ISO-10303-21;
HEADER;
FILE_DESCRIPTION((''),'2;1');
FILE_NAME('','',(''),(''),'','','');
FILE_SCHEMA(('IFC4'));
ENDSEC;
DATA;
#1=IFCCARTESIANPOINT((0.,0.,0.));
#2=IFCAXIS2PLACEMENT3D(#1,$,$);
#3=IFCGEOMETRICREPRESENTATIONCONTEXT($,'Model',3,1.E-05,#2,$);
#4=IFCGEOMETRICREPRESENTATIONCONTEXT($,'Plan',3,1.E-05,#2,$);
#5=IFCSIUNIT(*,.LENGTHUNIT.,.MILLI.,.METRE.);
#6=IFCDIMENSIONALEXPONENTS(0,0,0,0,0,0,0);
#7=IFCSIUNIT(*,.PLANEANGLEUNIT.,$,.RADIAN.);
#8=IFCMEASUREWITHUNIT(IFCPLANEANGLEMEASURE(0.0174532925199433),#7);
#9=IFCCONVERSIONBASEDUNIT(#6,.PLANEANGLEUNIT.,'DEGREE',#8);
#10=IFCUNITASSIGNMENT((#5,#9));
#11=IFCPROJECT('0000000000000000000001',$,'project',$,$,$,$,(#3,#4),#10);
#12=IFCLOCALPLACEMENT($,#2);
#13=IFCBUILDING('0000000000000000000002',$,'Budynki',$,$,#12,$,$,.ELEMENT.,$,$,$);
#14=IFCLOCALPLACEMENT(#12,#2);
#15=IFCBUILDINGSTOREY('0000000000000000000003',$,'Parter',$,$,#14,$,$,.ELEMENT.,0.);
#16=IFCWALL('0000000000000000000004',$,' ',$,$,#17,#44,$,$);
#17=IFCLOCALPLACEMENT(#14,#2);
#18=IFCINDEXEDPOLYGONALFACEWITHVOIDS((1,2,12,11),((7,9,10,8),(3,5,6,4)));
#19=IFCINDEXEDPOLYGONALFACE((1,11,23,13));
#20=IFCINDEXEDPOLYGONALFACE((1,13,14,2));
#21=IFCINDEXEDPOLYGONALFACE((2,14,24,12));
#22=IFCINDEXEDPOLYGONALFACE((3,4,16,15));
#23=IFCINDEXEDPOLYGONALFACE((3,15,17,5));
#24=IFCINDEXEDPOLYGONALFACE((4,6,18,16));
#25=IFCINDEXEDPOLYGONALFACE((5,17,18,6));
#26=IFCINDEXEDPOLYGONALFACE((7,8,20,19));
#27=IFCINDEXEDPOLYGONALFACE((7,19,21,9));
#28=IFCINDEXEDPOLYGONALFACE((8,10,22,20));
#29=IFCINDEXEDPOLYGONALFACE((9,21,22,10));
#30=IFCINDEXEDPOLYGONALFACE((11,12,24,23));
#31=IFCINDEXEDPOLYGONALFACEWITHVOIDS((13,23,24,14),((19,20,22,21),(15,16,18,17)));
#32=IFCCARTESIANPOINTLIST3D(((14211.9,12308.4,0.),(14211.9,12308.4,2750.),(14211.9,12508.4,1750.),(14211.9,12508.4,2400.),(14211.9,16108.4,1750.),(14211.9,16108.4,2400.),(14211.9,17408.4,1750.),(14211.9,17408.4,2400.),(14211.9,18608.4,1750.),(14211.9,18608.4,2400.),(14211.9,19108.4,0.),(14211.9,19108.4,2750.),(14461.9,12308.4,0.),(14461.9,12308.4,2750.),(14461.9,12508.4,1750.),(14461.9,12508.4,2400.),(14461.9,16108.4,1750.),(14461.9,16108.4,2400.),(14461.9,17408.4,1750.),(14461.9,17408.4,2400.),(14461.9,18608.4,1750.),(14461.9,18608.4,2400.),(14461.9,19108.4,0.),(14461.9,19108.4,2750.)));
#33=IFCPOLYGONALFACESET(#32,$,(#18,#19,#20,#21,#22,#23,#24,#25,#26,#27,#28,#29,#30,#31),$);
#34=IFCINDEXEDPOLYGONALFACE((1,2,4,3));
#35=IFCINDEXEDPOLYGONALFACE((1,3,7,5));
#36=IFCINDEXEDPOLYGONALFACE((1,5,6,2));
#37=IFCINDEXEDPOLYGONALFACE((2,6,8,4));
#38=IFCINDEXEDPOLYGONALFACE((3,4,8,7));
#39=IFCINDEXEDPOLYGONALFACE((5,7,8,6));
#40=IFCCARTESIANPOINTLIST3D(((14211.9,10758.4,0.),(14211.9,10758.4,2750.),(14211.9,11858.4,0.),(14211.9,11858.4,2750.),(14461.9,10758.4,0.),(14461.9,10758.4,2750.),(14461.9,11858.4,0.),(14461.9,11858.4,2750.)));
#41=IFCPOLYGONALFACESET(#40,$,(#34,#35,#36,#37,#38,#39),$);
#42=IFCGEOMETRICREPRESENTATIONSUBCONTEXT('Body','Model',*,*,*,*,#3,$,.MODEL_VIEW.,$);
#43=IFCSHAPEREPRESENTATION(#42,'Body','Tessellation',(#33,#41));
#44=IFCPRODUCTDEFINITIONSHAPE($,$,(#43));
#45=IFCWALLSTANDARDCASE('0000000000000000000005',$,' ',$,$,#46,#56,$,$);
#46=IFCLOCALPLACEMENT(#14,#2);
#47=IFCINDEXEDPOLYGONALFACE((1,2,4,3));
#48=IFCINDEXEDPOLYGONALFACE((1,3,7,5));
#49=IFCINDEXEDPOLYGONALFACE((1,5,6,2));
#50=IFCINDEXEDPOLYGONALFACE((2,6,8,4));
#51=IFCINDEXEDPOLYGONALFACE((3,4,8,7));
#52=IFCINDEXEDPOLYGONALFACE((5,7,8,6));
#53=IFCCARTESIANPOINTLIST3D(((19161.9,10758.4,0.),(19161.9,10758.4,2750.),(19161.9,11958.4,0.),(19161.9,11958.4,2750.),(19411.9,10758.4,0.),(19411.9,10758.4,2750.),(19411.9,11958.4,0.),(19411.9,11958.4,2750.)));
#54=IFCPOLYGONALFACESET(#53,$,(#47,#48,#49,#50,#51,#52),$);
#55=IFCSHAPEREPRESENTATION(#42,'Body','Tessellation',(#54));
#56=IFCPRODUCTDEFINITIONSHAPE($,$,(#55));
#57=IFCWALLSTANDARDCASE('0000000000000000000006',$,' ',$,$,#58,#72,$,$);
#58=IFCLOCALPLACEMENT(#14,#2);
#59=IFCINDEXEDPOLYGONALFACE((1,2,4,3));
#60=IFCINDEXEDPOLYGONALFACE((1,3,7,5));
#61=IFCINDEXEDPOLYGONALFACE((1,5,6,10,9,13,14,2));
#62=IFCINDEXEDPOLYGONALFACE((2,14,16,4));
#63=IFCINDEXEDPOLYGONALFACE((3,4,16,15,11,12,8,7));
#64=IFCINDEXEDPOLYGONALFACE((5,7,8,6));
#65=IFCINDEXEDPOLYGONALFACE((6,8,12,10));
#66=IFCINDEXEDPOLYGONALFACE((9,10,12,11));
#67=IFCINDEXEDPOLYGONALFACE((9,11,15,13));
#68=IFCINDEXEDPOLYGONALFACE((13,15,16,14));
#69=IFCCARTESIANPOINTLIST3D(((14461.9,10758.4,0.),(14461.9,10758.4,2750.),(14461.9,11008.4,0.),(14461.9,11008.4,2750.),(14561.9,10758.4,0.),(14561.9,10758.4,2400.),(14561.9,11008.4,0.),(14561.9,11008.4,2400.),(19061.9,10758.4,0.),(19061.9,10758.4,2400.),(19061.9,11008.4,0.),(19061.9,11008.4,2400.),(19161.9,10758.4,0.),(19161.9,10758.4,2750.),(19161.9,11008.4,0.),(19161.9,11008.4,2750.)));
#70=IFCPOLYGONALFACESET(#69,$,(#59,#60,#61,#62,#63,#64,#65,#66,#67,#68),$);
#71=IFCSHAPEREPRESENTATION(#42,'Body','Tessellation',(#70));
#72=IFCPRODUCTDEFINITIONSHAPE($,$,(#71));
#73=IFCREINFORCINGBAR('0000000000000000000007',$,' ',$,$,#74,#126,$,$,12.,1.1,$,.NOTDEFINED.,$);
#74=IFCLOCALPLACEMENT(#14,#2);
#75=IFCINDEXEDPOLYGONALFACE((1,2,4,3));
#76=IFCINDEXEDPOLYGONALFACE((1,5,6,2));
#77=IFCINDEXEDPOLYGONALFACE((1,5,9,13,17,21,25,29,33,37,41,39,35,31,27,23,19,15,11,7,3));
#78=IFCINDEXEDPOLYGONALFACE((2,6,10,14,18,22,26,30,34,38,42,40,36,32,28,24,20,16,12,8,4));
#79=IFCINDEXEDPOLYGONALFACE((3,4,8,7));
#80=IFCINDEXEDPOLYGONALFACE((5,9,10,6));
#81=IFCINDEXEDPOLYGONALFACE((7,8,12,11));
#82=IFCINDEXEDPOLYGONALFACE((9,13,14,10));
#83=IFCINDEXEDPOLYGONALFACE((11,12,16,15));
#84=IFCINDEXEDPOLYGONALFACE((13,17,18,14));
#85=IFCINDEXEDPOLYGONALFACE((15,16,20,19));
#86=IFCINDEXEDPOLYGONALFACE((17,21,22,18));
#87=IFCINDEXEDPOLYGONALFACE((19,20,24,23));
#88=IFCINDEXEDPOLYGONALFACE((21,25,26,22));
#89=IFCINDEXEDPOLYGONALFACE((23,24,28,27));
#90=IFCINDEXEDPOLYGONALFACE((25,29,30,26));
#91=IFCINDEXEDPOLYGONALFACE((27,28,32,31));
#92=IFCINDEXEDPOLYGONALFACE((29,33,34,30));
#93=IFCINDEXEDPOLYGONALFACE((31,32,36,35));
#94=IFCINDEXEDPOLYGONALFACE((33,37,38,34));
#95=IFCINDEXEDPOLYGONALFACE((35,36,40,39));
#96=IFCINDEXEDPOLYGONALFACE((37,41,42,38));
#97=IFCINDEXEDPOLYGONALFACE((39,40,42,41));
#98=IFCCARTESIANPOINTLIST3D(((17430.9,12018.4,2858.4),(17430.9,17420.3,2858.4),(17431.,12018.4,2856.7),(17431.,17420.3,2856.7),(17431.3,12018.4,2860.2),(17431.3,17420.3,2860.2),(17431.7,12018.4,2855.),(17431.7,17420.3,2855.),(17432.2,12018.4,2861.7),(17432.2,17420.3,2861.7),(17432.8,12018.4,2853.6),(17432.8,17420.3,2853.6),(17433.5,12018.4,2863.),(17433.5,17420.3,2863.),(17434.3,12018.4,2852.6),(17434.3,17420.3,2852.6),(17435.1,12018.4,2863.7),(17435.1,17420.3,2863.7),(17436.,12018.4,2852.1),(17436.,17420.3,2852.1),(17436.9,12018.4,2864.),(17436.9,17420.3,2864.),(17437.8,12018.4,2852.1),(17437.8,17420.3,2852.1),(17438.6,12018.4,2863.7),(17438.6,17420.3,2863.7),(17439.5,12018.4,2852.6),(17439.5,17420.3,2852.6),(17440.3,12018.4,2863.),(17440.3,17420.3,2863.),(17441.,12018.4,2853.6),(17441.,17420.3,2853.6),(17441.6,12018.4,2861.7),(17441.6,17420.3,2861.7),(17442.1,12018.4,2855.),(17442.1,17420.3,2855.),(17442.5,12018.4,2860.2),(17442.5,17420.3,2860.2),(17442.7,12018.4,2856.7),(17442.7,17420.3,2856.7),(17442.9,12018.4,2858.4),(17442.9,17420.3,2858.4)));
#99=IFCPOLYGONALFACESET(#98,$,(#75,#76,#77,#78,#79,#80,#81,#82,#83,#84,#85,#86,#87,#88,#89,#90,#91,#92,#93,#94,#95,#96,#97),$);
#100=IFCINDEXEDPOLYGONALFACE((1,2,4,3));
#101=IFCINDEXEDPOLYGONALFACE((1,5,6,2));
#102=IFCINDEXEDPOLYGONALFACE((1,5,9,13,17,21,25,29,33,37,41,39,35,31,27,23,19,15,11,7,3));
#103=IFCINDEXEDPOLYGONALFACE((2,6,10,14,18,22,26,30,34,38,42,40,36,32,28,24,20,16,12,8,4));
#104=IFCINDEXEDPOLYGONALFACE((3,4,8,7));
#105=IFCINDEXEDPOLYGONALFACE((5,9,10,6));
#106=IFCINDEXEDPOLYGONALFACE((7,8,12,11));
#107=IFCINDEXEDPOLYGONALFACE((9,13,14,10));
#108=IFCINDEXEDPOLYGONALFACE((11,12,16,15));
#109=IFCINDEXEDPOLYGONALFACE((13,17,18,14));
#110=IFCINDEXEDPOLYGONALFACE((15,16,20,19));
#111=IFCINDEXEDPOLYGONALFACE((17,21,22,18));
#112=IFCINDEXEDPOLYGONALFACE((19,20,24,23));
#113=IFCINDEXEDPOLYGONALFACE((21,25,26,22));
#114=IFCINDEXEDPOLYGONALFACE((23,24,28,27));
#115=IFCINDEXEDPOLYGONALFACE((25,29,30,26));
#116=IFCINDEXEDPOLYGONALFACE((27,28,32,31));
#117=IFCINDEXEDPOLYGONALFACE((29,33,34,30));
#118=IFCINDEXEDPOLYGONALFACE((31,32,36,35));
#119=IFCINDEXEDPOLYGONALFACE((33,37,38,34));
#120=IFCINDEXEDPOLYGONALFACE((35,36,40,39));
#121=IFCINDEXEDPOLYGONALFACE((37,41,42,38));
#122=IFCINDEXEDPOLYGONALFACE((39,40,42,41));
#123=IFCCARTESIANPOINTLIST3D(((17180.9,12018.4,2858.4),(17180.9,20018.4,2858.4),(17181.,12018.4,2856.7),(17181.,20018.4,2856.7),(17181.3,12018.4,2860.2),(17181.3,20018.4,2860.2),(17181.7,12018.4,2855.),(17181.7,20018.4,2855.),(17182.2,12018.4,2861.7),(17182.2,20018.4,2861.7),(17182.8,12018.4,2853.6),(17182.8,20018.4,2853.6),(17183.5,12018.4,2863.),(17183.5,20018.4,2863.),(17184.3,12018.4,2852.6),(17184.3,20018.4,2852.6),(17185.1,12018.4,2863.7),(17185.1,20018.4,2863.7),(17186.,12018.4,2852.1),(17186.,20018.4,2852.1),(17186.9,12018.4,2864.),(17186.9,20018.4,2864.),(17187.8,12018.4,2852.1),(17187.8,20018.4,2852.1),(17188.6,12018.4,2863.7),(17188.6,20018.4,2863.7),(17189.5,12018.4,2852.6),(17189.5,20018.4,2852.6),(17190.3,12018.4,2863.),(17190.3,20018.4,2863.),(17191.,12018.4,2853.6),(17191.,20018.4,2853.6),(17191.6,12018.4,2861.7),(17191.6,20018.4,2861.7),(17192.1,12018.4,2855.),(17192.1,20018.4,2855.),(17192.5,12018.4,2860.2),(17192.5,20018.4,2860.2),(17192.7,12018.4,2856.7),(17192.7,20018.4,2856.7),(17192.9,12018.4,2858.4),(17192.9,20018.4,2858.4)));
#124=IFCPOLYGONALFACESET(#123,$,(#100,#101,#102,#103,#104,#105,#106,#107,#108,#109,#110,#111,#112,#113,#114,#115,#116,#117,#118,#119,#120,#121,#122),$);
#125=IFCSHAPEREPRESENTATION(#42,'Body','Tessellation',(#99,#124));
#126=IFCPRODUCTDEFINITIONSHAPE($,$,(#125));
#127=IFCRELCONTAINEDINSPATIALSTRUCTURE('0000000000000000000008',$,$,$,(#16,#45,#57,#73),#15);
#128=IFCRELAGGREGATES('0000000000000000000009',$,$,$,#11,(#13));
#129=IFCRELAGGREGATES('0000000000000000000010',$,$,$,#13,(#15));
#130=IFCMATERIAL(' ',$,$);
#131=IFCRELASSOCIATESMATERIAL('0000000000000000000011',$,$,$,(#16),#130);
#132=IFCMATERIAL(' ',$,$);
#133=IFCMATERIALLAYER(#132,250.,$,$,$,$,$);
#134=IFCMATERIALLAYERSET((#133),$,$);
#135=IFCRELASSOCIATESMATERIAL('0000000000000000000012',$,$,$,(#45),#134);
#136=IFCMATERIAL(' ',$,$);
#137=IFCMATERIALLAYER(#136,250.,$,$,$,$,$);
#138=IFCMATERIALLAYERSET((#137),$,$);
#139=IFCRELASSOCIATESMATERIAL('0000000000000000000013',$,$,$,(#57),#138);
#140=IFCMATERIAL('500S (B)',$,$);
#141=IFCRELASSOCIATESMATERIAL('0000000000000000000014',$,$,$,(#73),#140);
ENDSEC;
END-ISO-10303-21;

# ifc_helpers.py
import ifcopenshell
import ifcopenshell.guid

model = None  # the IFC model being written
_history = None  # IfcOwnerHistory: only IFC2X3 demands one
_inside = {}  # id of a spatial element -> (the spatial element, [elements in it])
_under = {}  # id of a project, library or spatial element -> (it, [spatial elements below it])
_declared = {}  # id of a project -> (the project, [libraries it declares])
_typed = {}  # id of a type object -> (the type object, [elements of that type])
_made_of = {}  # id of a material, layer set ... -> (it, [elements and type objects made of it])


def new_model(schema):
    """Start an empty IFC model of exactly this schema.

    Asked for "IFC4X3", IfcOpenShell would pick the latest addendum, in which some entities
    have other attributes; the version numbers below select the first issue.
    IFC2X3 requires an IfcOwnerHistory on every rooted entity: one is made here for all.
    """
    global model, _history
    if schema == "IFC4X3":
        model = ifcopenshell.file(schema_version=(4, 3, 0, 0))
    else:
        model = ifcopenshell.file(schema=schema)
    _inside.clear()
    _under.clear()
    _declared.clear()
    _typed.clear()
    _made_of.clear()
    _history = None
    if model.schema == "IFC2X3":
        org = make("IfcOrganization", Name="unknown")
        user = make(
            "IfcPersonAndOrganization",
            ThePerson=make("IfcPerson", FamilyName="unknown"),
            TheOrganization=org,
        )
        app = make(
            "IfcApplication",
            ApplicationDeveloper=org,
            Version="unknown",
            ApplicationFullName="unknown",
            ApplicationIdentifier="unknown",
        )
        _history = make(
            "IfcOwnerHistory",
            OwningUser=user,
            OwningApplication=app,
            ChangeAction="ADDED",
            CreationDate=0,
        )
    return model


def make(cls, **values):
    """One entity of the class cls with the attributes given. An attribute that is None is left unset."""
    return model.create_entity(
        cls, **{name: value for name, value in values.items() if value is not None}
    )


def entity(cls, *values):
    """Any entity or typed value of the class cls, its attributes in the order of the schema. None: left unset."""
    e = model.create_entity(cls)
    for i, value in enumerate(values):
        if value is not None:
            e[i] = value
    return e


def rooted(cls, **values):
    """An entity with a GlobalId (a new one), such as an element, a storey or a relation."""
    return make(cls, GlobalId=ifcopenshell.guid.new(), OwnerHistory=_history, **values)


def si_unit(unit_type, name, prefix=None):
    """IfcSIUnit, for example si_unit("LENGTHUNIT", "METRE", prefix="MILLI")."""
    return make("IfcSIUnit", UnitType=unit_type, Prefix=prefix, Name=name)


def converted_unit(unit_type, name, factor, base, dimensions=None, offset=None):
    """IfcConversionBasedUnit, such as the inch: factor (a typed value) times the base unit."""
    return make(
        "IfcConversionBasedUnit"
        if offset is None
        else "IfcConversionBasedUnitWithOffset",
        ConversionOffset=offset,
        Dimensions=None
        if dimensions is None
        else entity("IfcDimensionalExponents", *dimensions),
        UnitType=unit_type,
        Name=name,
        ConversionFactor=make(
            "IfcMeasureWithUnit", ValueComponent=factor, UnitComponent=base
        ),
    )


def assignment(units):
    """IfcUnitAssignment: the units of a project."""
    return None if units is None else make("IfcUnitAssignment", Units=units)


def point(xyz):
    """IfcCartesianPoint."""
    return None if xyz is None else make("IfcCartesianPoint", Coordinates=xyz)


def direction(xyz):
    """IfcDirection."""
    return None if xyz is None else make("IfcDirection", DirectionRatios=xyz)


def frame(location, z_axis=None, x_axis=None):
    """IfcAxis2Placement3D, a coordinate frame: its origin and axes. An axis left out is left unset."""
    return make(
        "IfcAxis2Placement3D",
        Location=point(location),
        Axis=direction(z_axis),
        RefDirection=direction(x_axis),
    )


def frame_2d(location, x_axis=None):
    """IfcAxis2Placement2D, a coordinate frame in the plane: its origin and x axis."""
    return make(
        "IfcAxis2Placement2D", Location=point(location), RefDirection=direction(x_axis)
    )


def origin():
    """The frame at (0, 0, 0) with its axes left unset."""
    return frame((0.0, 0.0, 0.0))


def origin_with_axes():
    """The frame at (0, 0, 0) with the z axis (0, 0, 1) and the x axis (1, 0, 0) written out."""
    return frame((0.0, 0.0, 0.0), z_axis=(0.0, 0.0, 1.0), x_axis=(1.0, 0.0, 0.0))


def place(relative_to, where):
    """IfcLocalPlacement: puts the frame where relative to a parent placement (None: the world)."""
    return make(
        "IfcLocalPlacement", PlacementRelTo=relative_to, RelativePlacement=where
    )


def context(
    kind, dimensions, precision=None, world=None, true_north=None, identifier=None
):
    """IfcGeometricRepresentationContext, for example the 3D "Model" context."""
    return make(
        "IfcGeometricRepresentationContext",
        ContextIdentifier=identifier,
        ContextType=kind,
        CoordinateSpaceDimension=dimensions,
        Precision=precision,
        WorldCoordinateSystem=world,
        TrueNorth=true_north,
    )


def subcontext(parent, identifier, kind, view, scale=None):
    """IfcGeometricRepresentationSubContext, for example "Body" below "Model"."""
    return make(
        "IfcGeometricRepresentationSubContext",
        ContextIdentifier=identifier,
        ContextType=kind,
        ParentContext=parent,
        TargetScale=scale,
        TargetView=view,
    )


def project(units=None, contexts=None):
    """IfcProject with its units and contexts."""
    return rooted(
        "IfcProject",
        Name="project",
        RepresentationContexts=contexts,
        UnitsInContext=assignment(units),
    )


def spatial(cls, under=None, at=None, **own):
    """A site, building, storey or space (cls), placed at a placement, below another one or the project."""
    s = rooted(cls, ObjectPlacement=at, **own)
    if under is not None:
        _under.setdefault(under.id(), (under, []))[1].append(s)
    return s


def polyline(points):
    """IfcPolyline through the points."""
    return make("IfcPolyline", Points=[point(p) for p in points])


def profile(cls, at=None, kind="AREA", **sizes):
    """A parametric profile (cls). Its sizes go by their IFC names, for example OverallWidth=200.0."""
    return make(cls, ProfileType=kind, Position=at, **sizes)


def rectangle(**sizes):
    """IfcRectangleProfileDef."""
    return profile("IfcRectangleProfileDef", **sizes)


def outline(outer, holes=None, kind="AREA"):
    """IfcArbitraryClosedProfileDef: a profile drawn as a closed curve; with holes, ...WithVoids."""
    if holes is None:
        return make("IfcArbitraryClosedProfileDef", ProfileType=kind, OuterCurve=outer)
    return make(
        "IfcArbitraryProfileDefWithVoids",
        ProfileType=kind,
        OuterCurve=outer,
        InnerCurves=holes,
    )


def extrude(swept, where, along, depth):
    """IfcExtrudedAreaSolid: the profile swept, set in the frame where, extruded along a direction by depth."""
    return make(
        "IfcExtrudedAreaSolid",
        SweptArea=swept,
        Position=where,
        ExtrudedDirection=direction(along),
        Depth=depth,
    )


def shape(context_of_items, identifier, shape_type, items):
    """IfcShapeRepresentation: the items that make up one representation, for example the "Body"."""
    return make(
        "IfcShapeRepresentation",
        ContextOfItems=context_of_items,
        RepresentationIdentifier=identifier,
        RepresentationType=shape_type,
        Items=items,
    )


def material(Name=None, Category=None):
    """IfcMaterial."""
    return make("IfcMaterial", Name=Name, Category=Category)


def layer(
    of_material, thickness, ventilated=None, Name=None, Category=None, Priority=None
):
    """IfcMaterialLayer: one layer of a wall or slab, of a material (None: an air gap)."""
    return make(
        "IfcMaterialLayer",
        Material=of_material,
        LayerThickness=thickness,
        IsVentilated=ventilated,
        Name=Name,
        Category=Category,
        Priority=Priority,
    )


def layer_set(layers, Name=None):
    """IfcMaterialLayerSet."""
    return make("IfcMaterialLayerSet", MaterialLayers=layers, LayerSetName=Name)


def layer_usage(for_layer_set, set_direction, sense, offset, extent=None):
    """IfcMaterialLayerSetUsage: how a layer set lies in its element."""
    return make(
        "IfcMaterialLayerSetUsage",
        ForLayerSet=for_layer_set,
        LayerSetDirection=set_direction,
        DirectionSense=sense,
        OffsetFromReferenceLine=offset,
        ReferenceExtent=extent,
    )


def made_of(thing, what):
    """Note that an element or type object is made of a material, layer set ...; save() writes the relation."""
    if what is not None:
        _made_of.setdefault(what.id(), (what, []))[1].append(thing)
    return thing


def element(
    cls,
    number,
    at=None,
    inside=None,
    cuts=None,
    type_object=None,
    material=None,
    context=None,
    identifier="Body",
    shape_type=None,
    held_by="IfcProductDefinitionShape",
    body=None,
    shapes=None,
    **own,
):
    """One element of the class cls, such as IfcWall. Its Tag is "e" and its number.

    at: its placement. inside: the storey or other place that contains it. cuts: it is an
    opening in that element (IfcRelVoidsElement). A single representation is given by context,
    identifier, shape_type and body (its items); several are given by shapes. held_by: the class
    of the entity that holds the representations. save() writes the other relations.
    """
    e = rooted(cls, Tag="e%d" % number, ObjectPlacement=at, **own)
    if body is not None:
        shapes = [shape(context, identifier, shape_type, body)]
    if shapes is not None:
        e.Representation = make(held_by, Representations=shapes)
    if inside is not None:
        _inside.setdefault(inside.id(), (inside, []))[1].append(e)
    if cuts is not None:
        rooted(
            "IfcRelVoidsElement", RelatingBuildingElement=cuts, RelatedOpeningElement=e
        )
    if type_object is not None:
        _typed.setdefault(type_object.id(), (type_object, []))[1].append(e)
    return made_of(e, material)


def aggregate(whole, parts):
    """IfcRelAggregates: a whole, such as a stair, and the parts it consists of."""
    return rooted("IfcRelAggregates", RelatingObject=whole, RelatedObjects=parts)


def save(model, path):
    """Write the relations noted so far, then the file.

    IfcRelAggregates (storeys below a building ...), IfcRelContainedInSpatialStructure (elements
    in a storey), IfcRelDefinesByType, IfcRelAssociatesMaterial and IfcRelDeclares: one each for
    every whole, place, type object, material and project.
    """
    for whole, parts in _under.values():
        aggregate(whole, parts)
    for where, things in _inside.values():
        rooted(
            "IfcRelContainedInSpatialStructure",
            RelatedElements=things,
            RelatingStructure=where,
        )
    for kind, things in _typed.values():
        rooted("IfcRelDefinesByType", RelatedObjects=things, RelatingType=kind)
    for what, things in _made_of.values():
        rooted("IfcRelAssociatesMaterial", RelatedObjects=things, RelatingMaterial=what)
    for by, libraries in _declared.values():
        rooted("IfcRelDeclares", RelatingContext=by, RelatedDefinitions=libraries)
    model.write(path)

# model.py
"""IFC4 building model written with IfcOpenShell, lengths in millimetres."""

from ifc_helpers import new_model, entity, si_unit, converted_unit, frame, frame_2d, origin, origin_with_axes, place, context, subcontext, project, spatial, polyline, rectangle, outline, extrude, material, layer, layer_set, layer_usage, element, save


model = new_model("IFC4")

# Units and contexts
model_context = context("Model", 3, precision=1e-05, world=origin())
plan_context = context("Plan", 3, precision=1e-05, world=origin())
body_context = subcontext(model_context, "Body", "Model", "MODEL_VIEW")
ifc_project = project(units=[si_unit("LENGTHUNIT", "METRE", prefix="MILLI"), converted_unit("PLANEANGLEUNIT", "DEGREE", entity("IfcPlaneAngleMeasure", 0.0174532925199433), si_unit("PLANEANGLEUNIT", "RADIAN"), dimensions=[0, 0, 0, 0, 0, 0, 0])], contexts=[model_context, plan_context])

# Building, storey
building_placement = place(None, origin())
building = spatial("IfcBuilding", under=ifc_project, at=building_placement, Name="Budynki", CompositionType="ELEMENT")
storey_placement = place(building_placement, origin())
storey = spatial("IfcBuildingStorey", under=building, at=storey_placement, Name="Parter", CompositionType="ELEMENT", Elevation=0.0)

# Wall, openings
ifc_material_1 = material(Name=" ")
wall_1_placement = place(storey_placement, frame((14461.9, 10758.4, 0.0), z_axis=(0.0, 0.0, 1.0), x_axis=(0.0, 1.0, 0.0)))
wall_1 = element("IfcWall", 1, at=wall_1_placement, inside=storey, material=ifc_material_1, Name=" ", context=body_context, shape_type="SweptSolid", body=[
    extrude(rectangle(XDim=250.0, YDim=6800.0, at=frame_2d((3400.0, -125.0), x_axis=(0.0, -1.0))), frame((1550.0, 250.0, 0.0), z_axis=(0.0, 0.0, 1.0), x_axis=(1.0, 0.0, 0.0)), (0.0, 0.0, 1.0), 2750.0),
    extrude(rectangle(XDim=250.0, YDim=1100.0, at=frame_2d((-550.0, 125.0), x_axis=(0.0, 1.0))), frame((1100.0, 0.0, 0.0), z_axis=(0.0, 0.0, 1.0), x_axis=(1.0, 0.0, 0.0)), (0.0, 0.0, 1.0), 2750.0),
])
opening_1_placement = place(wall_1_placement, frame((5350.0, 250.0, 1750.0), z_axis=(0.0, -1.0, 0.0), x_axis=(0.0, 0.0, 1.0)))
element("IfcOpeningStandardCase", 2, at=opening_1_placement, cuts=wall_1, PredefinedType="OPENING", context=body_context, shape_type="SweptSolid", body=[
    extrude(outline(polyline([(0.0, 3600.0), (650.0, 3600.0), (650.0, 0.0), (0.0, 0.0), (0.0, 3600.0)])), origin_with_axes(), (0.0, 0.0, 1.0), 250.0),
])
opening_2_placement = place(wall_1_placement, frame((6650.0, 0.0, 1750.0), z_axis=(0.0, 1.0, 0.0), x_axis=(0.0, 0.0, 1.0)))
element("IfcOpeningStandardCase", 3, at=opening_2_placement, cuts=wall_1, PredefinedType="OPENING", context=body_context, shape_type="SweptSolid", body=[
    extrude(outline(polyline([(0.0, 1200.0), (650.0, 1200.0), (650.0, 0.0), (0.0, 0.0), (0.0, 1200.0)])), origin_with_axes(), (0.0, 0.0, 1.0), 250.0),
])

# Wall
ifc_material_2 = material(Name=" ")
ifc_layer_1 = layer(ifc_material_2, 250.0)
ifc_layer_set_1 = layer_set([ifc_layer_1])
ifc_layer_usage_1 = layer_usage(ifc_layer_set_1, "AXIS2", "POSITIVE", 0.0)
wall_2_placement = place(storey_placement, frame((19161.9, 11958.4, 0.0), z_axis=(0.0, 0.0, 1.0), x_axis=(0.0, -1.0, 0.0)))
element("IfcWallStandardCase", 4, at=wall_2_placement, inside=storey, material=ifc_layer_usage_1, Name=" ", context=body_context, shape_type="SweptSolid", body=[
    extrude(rectangle(XDim=1200.0, YDim=250.0, at=frame_2d((600.0, 125.0), x_axis=(1.0, 0.0))), origin_with_axes(), (0.0, 0.0, 1.0), 2750.0),
])

# Wall, opening
ifc_material_3 = material(Name=" ")
ifc_layer_2 = layer(ifc_material_3, 250.0)
ifc_layer_set_2 = layer_set([ifc_layer_2])
ifc_layer_usage_2 = layer_usage(ifc_layer_set_2, "AXIS2", "POSITIVE", 0.0)
wall_3_placement = place(storey_placement, frame((19161.9, 11008.4, 0.0), z_axis=(0.0, 0.0, 1.0), x_axis=(-1.0, 0.0, 0.0)))
wall_3 = element("IfcWallStandardCase", 5, at=wall_3_placement, inside=storey, material=ifc_layer_usage_2, Name=" ", context=body_context, shape_type="SweptSolid", body=[
    extrude(rectangle(XDim=4700.0, YDim=250.0, at=frame_2d((2350.0, 125.0), x_axis=(1.0, 0.0))), origin_with_axes(), (0.0, 0.0, 1.0), 2750.0),
])
opening_3_placement = place(wall_3_placement, frame((4600.0, 250.0, 0.0), z_axis=(0.0, -1.0, 0.0), x_axis=(0.0, 0.0, 1.0)))
element("IfcOpeningStandardCase", 6, at=opening_3_placement, cuts=wall_3, PredefinedType="OPENING", context=body_context, shape_type="SweptSolid", body=[
    extrude(outline(polyline([(0.0, 4500.0), (2400.0, 4500.0), (2400.0, 0.0), (0.0, 0.0), (0.0, 4500.0)])), origin_with_axes(), (0.0, 0.0, 1.0), 250.0),
])

# Reinforcing bar
ifc_material_4 = material(Name="500S (B)")
reinforcing_bar_1_placement = place(storey_placement, frame((17436.9, 12018.4, 2858.0)))
element("IfcReinforcingBar", 7, at=reinforcing_bar_1_placement, inside=storey, material=ifc_material_4, Name=" ", CrossSectionArea=1.1, NominalDiameter=12.0, PredefinedType="NOTDEFINED", context=body_context, shape_type="AdvancedSweptSolid", body=[
    entity("IfcSweptDiskSolid", entity("IfcPolyline", [entity("IfcCartesianPoint", [0.0, 0.0, 0.0]), entity("IfcCartesianPoint", [0.0, 5401.9, 0.0])]), 6.0, None, 0.0, 1.0),
    entity("IfcSweptDiskSolid", entity("IfcPolyline", [entity("IfcCartesianPoint", [-250.0, 0.0, 0.0]), entity("IfcCartesianPoint", [-250.0, 8000.0, 0.0])]), 6.0, None, 0.0, 1.0),
])

save(model, "model.ifc")
